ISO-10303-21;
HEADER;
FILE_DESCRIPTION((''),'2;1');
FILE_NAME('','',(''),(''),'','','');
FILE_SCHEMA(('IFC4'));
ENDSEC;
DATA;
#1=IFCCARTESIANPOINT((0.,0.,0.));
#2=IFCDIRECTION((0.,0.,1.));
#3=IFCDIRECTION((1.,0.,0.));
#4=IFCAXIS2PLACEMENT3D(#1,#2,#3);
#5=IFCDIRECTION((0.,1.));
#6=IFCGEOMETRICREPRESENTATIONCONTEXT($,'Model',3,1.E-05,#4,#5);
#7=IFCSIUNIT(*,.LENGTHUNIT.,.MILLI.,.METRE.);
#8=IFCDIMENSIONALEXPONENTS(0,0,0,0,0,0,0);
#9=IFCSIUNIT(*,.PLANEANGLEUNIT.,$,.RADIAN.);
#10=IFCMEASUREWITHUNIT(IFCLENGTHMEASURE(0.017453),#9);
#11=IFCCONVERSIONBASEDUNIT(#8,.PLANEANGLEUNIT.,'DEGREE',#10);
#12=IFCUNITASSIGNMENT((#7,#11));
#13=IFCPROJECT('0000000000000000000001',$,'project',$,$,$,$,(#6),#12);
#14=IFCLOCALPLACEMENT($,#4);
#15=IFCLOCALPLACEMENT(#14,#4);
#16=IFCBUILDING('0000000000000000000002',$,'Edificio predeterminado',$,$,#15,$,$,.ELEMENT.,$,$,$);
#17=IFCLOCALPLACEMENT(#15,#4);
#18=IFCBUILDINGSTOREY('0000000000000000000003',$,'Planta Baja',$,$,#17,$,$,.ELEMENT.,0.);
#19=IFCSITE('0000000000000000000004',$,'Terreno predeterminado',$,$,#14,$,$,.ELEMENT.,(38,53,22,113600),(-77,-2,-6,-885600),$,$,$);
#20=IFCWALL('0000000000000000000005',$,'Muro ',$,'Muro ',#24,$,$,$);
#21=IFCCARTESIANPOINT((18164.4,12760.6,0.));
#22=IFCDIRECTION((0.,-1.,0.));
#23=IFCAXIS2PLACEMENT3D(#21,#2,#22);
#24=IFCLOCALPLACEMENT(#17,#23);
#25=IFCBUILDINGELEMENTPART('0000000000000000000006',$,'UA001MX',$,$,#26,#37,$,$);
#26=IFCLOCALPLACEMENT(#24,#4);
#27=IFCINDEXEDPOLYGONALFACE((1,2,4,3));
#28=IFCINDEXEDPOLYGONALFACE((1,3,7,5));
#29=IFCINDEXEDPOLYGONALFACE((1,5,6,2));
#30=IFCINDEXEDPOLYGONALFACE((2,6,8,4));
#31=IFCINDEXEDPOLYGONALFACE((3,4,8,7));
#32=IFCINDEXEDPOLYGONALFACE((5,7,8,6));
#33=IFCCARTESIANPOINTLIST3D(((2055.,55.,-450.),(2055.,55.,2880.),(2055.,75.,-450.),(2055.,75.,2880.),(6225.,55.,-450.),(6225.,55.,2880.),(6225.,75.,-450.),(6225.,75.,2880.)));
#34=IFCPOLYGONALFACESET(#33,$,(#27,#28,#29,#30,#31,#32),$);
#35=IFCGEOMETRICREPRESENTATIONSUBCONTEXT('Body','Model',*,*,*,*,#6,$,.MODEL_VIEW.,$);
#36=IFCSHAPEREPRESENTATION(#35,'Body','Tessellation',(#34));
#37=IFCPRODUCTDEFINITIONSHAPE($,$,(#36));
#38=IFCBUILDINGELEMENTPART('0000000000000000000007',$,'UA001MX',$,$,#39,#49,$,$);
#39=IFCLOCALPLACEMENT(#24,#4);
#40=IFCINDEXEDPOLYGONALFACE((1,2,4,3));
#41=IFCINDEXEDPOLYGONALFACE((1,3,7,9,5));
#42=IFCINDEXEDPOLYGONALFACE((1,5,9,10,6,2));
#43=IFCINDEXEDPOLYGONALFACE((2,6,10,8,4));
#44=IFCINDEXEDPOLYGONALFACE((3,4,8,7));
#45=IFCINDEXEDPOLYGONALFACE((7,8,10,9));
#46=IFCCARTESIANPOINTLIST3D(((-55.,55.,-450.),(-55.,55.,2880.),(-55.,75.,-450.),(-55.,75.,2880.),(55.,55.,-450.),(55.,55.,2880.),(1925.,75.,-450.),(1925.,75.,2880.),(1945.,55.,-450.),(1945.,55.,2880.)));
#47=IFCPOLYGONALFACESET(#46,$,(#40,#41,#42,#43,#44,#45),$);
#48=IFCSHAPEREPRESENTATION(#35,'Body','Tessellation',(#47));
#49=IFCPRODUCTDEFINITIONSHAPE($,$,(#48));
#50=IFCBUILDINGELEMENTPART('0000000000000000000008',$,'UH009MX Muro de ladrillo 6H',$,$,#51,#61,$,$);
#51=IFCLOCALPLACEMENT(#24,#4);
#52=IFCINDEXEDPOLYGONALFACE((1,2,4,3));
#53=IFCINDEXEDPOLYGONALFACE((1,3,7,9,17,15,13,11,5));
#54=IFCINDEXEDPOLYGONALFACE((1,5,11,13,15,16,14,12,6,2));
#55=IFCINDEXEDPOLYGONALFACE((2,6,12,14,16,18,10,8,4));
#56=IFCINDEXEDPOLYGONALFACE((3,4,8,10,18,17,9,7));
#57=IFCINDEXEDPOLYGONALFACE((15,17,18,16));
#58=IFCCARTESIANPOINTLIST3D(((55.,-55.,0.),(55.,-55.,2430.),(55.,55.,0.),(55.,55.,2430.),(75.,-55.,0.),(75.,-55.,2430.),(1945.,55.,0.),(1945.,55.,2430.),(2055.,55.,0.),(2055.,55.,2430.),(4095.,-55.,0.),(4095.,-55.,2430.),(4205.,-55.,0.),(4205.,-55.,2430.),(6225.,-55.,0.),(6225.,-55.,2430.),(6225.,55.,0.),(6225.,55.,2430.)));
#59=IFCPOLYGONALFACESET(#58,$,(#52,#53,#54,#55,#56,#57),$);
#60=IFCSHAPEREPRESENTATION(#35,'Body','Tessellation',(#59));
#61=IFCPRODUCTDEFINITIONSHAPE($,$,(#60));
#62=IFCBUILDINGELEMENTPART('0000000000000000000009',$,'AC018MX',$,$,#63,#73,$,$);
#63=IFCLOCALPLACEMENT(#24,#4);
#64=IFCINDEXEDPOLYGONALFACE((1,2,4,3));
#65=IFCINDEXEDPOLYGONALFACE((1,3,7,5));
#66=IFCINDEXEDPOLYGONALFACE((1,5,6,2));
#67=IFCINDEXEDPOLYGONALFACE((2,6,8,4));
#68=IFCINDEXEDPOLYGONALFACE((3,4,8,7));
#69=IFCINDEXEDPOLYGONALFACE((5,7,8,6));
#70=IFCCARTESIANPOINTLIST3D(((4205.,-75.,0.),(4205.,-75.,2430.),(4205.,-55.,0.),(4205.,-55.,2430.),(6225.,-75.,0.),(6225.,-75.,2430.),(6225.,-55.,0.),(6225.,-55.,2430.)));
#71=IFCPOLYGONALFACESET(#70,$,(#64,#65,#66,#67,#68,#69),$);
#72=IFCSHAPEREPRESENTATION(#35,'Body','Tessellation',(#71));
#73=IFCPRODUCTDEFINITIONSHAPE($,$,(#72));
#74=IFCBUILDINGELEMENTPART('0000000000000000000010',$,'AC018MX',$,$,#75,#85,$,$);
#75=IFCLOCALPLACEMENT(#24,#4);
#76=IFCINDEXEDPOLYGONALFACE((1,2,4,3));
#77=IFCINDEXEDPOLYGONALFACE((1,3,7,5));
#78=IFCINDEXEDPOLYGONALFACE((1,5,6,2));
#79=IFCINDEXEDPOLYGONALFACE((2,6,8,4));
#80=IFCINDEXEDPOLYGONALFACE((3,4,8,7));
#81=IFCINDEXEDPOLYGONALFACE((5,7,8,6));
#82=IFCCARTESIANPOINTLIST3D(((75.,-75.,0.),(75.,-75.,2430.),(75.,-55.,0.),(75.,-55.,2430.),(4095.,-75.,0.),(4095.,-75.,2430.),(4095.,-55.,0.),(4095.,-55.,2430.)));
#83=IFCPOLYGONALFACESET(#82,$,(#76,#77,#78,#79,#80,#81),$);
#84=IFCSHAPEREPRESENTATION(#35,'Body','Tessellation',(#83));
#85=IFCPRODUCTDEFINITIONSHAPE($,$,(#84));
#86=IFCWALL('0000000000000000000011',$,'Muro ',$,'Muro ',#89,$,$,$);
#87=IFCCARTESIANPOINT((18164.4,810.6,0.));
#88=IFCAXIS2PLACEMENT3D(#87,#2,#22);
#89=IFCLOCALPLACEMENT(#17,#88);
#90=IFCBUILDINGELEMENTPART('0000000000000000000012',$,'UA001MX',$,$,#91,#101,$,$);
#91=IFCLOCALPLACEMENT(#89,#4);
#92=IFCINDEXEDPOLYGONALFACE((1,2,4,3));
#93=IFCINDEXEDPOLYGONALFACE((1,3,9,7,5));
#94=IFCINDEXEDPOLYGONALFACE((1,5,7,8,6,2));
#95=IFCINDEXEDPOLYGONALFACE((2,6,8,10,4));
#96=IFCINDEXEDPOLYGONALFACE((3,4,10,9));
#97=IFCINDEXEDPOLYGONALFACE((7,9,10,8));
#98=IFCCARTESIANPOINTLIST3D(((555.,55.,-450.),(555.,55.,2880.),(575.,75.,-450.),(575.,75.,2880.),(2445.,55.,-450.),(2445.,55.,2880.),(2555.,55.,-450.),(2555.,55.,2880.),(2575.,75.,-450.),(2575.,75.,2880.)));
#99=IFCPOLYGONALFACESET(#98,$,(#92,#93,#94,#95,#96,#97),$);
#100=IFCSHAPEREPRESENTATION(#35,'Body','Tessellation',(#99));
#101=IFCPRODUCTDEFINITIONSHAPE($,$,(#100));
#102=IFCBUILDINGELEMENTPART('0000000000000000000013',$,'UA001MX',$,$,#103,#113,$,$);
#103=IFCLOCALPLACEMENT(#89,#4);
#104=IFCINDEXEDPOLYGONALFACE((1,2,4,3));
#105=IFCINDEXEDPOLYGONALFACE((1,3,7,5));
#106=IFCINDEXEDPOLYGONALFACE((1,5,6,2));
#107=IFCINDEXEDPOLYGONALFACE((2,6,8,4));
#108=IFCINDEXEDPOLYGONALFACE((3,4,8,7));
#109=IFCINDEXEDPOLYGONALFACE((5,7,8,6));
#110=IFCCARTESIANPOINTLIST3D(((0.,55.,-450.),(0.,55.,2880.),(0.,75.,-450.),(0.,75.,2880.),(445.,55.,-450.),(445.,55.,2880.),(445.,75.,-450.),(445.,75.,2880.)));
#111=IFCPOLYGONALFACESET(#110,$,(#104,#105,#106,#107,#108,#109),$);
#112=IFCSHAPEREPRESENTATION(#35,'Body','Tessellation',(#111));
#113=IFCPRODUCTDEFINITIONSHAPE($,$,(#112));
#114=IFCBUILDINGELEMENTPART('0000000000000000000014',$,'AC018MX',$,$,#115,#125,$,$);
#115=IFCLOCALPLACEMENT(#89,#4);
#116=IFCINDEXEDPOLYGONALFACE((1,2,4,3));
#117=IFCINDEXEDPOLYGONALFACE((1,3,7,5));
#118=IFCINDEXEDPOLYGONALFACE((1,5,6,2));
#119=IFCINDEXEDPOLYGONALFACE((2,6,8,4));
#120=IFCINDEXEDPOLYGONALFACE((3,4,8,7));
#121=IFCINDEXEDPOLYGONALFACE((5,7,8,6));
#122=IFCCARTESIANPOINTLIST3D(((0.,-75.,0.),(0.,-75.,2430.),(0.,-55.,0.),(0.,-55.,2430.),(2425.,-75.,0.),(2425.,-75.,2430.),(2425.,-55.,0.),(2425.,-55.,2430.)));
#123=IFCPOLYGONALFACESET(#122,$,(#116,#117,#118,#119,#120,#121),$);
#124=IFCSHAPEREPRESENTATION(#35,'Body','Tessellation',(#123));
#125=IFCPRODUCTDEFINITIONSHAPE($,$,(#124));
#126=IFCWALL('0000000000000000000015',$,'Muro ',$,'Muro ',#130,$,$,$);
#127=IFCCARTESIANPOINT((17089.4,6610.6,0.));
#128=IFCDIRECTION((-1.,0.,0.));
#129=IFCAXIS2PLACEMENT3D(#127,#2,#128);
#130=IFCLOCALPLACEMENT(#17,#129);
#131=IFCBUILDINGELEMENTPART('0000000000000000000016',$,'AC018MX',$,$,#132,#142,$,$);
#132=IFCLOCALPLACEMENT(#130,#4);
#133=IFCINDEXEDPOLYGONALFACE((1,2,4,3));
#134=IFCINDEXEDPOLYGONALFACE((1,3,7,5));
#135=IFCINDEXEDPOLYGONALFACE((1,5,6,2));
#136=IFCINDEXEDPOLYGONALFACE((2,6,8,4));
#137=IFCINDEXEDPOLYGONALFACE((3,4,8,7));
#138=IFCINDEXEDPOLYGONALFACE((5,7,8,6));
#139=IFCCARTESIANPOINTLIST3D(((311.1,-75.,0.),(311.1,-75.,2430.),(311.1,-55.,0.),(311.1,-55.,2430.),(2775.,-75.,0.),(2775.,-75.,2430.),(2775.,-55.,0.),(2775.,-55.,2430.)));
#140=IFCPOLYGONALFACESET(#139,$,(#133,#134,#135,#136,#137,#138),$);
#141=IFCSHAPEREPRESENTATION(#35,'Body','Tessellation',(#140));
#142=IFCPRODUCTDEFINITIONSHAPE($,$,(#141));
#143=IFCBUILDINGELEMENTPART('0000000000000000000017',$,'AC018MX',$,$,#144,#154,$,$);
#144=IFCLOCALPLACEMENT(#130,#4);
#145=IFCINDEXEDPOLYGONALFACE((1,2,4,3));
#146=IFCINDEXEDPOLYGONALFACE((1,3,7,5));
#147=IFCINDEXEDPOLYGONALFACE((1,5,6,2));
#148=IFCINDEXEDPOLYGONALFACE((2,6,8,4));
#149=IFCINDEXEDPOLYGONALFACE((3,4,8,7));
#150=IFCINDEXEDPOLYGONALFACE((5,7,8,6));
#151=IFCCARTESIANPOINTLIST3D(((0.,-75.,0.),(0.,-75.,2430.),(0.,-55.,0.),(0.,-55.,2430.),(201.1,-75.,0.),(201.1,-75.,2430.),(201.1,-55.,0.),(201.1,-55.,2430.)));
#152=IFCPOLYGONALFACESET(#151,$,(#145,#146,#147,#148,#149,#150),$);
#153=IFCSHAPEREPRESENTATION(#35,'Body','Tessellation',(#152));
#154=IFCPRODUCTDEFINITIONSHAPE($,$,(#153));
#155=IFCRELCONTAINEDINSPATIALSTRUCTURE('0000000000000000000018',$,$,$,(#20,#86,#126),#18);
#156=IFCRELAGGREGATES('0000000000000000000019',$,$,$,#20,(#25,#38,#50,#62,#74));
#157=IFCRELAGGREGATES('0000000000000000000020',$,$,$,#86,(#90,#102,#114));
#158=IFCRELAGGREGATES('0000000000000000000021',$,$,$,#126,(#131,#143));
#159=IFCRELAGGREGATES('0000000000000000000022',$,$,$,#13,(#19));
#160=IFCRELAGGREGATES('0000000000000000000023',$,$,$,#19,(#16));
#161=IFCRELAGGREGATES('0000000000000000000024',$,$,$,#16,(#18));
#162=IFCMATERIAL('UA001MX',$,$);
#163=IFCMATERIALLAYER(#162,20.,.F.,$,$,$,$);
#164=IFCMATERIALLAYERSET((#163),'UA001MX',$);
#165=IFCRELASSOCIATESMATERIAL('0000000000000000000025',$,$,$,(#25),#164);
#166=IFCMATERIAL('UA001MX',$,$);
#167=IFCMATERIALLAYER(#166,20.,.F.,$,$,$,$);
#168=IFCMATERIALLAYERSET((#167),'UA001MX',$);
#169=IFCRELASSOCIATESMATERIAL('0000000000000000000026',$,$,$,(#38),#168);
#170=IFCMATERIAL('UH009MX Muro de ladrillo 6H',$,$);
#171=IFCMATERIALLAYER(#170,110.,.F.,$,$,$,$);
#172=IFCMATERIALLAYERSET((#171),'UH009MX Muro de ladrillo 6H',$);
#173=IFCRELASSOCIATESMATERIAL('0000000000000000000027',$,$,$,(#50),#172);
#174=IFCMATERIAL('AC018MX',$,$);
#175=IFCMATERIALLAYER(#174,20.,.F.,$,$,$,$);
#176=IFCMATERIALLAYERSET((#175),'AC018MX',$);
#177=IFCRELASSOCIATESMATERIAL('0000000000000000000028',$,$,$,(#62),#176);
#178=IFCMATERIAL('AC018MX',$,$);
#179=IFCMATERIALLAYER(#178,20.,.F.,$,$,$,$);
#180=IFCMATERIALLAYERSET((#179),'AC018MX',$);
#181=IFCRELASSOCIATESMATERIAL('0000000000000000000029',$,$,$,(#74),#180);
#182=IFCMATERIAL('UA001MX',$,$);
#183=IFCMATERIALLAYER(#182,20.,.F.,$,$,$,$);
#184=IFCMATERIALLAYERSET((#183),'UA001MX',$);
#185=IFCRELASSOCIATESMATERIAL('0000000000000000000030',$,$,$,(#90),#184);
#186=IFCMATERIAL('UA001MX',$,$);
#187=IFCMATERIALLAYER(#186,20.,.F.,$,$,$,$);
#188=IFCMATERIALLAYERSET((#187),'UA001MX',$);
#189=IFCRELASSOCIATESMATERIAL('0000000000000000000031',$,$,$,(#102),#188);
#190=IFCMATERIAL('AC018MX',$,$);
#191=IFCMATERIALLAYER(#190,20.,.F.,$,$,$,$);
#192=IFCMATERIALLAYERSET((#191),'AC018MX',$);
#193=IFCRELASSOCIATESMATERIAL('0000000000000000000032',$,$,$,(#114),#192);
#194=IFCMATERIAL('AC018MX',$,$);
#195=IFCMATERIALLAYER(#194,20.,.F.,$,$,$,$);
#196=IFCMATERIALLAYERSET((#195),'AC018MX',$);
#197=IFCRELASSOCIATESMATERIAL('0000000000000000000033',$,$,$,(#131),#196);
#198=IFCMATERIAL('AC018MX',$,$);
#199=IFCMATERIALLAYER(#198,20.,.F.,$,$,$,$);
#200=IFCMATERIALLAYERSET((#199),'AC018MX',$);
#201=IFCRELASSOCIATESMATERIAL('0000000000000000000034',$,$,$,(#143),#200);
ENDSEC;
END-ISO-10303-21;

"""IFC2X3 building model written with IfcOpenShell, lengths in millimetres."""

from ifc_helpers import new_model, entity, si_unit, converted_unit, direction, frame, origin_with_axes, place, context, subcontext, project, spatial, polyline, outline, extrude, material, layer, layer_set, layer_usage, element, aggregate, save


model = new_model("IFC2X3")

# Units and contexts
model_context = context("Model", 3, precision=1e-05, world=origin_with_axes(), true_north=direction((0.0, 1.0)))
body_context = subcontext(model_context, "Body", "Model", "MODEL_VIEW")
ifc_project = project(units=[si_unit("LENGTHUNIT", "METRE", prefix="MILLI"), converted_unit("PLANEANGLEUNIT", "DEGREE", entity("IfcLengthMeasure", 0.017453), si_unit("PLANEANGLEUNIT", "RADIAN"), dimensions=[0, 0, 0, 0, 0, 0, 0])], contexts=[model_context])

# Site, building, storey
site_placement = place(None, origin_with_axes())
site = spatial("IfcSite", under=ifc_project, at=site_placement, Name="Terreno predeterminado", CompositionType="ELEMENT", RefLatitude=(38, 53, 22, 113600), RefLongitude=(-77, -2, -6, -885600))
building_placement = place(site_placement, origin_with_axes())
building = spatial("IfcBuilding", under=site, at=building_placement, Name="Edificio predeterminado", CompositionType="ELEMENT")
storey_placement = place(building_placement, origin_with_axes())
storey = spatial("IfcBuildingStorey", under=building, at=storey_placement, Name="Planta Baja", CompositionType="ELEMENT", Elevation=0.0)

# Walls, building element parts
wall_1_placement = place(storey_placement, frame((18164.4, 12760.6, 0.0), z_axis=(0.0, 0.0, 1.0), x_axis=(0.0, -1.0, 0.0)))
wall_1 = element("IfcWall", 1, at=wall_1_placement, inside=storey, Name="Muro ", ObjectType="Muro ")
ifc_material_1 = material(Name="UA001MX")
ifc_layer_1 = layer(ifc_material_1, 20.0, ventilated=False)
ifc_layer_set_1 = layer_set([ifc_layer_1], Name="UA001MX")
ifc_layer_usage_1 = layer_usage(ifc_layer_set_1, "AXIS2", "NEGATIVE", -75.0)
building_element_part_1_placement = place(wall_1_placement, origin_with_axes())
building_element_part_1 = element("IfcBuildingElementPart", 2, at=building_element_part_1_placement, material=ifc_layer_usage_1, Name="UA001MX", context=body_context, shape_type="SweptSolid", body=[
    extrude(outline(polyline([(6225.0, 75.0), (6225.0, 55.0), (2055.0, 55.0), (2055.0, 75.0), (6225.0, 75.0)])), frame((0.0, 0.0, -450.0), z_axis=(0.0, 0.0, 1.0), x_axis=(1.0, 0.0, 0.0)), (0.0, 0.0, 1.0), 3330.0),
])
ifc_material_2 = material(Name="UA001MX")
ifc_layer_2 = layer(ifc_material_2, 20.0, ventilated=False)
ifc_layer_set_2 = layer_set([ifc_layer_2], Name="UA001MX")
ifc_layer_usage_2 = layer_usage(ifc_layer_set_2, "AXIS2", "NEGATIVE", -75.0)
building_element_part_2_placement = place(wall_1_placement, origin_with_axes())
building_element_part_2 = element("IfcBuildingElementPart", 3, at=building_element_part_2_placement, material=ifc_layer_usage_2, Name="UA001MX", context=body_context, shape_type="SweptSolid", body=[
    extrude(outline(polyline([(1925.0, 75.0), (1945.0, 55.0), (55.0, 55.0), (-55.0, 55.0), (-55.0, 75.0), (1925.0, 75.0)])), frame((0.0, 0.0, -450.0), z_axis=(0.0, 0.0, 1.0), x_axis=(1.0, 0.0, 0.0)), (0.0, 0.0, 1.0), 3330.0),
])
ifc_material_3 = material(Name="UH009MX Muro de ladrillo 6H")
ifc_layer_3 = layer(ifc_material_3, 110.0, ventilated=False)
ifc_layer_set_3 = layer_set([ifc_layer_3], Name="UH009MX Muro de ladrillo 6H")
ifc_layer_usage_3 = layer_usage(ifc_layer_set_3, "AXIS2", "NEGATIVE", -55.0)
building_element_part_3_placement = place(wall_1_placement, origin_with_axes())
building_element_part_3 = element("IfcBuildingElementPart", 4, at=building_element_part_3_placement, material=ifc_layer_usage_3, Name="UH009MX Muro de ladrillo 6H", context=body_context, shape_type="SweptSolid", body=[
    extrude(outline(polyline([(6225.0, 55.0), (6225.0, -55.0), (4205.0, -55.0), (4095.0, -55.0), (75.0, -55.0), (55.0, -55.0), (55.0, 55.0), (1945.0, 55.0), (2055.0, 55.0), (6225.0, 55.0)])), origin_with_axes(), (0.0, 0.0, 1.0), 2430.0),
])
ifc_material_4 = material(Name="AC018MX")
ifc_layer_4 = layer(ifc_material_4, 20.0, ventilated=False)
ifc_layer_set_4 = layer_set([ifc_layer_4], Name="AC018MX")
ifc_layer_usage_4 = layer_usage(ifc_layer_set_4, "AXIS2", "NEGATIVE", 55.0)
building_element_part_4_placement = place(wall_1_placement, origin_with_axes())
building_element_part_4 = element("IfcBuildingElementPart", 5, at=building_element_part_4_placement, material=ifc_layer_usage_4, Name="AC018MX", context=body_context, shape_type="SweptSolid", body=[
    extrude(outline(polyline([(6225.0, -55.0), (6225.0, -75.0), (4205.0, -75.0), (4205.0, -55.0), (6225.0, -55.0)])), origin_with_axes(), (0.0, 0.0, 1.0), 2430.0),
])
ifc_material_5 = material(Name="AC018MX")
ifc_layer_5 = layer(ifc_material_5, 20.0, ventilated=False)
ifc_layer_set_5 = layer_set([ifc_layer_5], Name="AC018MX")
ifc_layer_usage_5 = layer_usage(ifc_layer_set_5, "AXIS2", "NEGATIVE", 55.0)
building_element_part_5_placement = place(wall_1_placement, origin_with_axes())
building_element_part_5 = element("IfcBuildingElementPart", 6, at=building_element_part_5_placement, material=ifc_layer_usage_5, Name="AC018MX", context=body_context, shape_type="SweptSolid", body=[
    extrude(outline(polyline([(4095.0, -55.0), (4095.0, -75.0), (75.0, -75.0), (75.0, -55.0), (4095.0, -55.0)])), origin_with_axes(), (0.0, 0.0, 1.0), 2430.0),
])
aggregate(wall_1, [building_element_part_1, building_element_part_2, building_element_part_3, building_element_part_4, building_element_part_5])
wall_2_placement = place(storey_placement, frame((18164.4, 810.6, 0.0), z_axis=(0.0, 0.0, 1.0), x_axis=(0.0, -1.0, 0.0)))
wall_2 = element("IfcWall", 7, at=wall_2_placement, inside=storey, Name="Muro ", ObjectType="Muro ")
ifc_material_6 = material(Name="UA001MX")
ifc_layer_6 = layer(ifc_material_6, 20.0, ventilated=False)
ifc_layer_set_6 = layer_set([ifc_layer_6], Name="UA001MX")
ifc_layer_usage_6 = layer_usage(ifc_layer_set_6, "AXIS2", "NEGATIVE", -75.0)
building_element_part_6_placement = place(wall_2_placement, origin_with_axes())
building_element_part_6 = element("IfcBuildingElementPart", 8, at=building_element_part_6_placement, material=ifc_layer_usage_6, Name="UA001MX", context=body_context, shape_type="SweptSolid", body=[
    extrude(outline(polyline([(2575.0, 75.0), (2555.0, 55.0), (2445.0, 55.0), (555.0, 55.0), (575.0, 75.0), (2575.0, 75.0)])), frame((0.0, 0.0, -450.0), z_axis=(0.0, 0.0, 1.0), x_axis=(1.0, 0.0, 0.0)), (0.0, 0.0, 1.0), 3330.0),
])
ifc_material_7 = material(Name="UA001MX")
ifc_layer_7 = layer(ifc_material_7, 20.0, ventilated=False)
ifc_layer_set_7 = layer_set([ifc_layer_7], Name="UA001MX")
ifc_layer_usage_7 = layer_usage(ifc_layer_set_7, "AXIS2", "NEGATIVE", -75.0)
building_element_part_7_placement = place(wall_2_placement, origin_with_axes())
building_element_part_7 = element("IfcBuildingElementPart", 9, at=building_element_part_7_placement, material=ifc_layer_usage_7, Name="UA001MX", context=body_context, shape_type="SweptSolid", body=[
    extrude(outline(polyline([(445.0, 75.0), (445.0, 55.0), (0.0, 55.0), (0.0, 75.0), (445.0, 75.0)])), frame((0.0, 0.0, -450.0), z_axis=(0.0, 0.0, 1.0), x_axis=(1.0, 0.0, 0.0)), (0.0, 0.0, 1.0), 3330.0),
])
ifc_material_8 = material(Name="AC018MX")
ifc_layer_8 = layer(ifc_material_8, 20.0, ventilated=False)
ifc_layer_set_8 = layer_set([ifc_layer_8], Name="AC018MX")
ifc_layer_usage_8 = layer_usage(ifc_layer_set_8, "AXIS2", "NEGATIVE", 55.0)
building_element_part_8_placement = place(wall_2_placement, origin_with_axes())
building_element_part_8 = element("IfcBuildingElementPart", 10, at=building_element_part_8_placement, material=ifc_layer_usage_8, Name="AC018MX", context=body_context, shape_type="SweptSolid", body=[
    extrude(outline(polyline([(2425.0, -55.0), (2425.0, -75.0), (0.0, -75.0), (0.0, -55.0), (2425.0, -55.0)])), origin_with_axes(), (0.0, 0.0, 1.0), 2430.0),
])
aggregate(wall_2, [building_element_part_6, building_element_part_7, building_element_part_8])
wall_3_placement = place(storey_placement, frame((17089.4, 6610.6, 0.0), z_axis=(0.0, 0.0, 1.0), x_axis=(-1.0, 0.0, 0.0)))
wall_3 = element("IfcWall", 11, at=wall_3_placement, inside=storey, Name="Muro ", ObjectType="Muro ")
ifc_material_9 = material(Name="AC018MX")
ifc_layer_9 = layer(ifc_material_9, 20.0, ventilated=False)
ifc_layer_set_9 = layer_set([ifc_layer_9], Name="AC018MX")
ifc_layer_usage_9 = layer_usage(ifc_layer_set_9, "AXIS2", "NEGATIVE", 55.0)
building_element_part_9_placement = place(wall_3_placement, origin_with_axes())
building_element_part_9 = element("IfcBuildingElementPart", 12, at=building_element_part_9_placement, material=ifc_layer_usage_9, Name="AC018MX", context=body_context, shape_type="SweptSolid", body=[
    extrude(outline(polyline([(2775.0, -55.0), (2775.0, -75.0), (311.1, -75.0), (311.1, -55.0), (2775.0, -55.0)])), origin_with_axes(), (0.0, 0.0, 1.0), 2430.0),
])
ifc_material_10 = material(Name="AC018MX")
ifc_layer_10 = layer(ifc_material_10, 20.0, ventilated=False)
ifc_layer_set_10 = layer_set([ifc_layer_10], Name="AC018MX")
ifc_layer_usage_10 = layer_usage(ifc_layer_set_10, "AXIS2", "NEGATIVE", 55.0)
building_element_part_10_placement = place(wall_3_placement, origin_with_axes())
building_element_part_10 = element("IfcBuildingElementPart", 13, at=building_element_part_10_placement, material=ifc_layer_usage_10, Name="AC018MX", context=body_context, shape_type="SweptSolid", body=[
    extrude(outline(polyline([(201.1, -55.0), (201.1, -75.0), (0.0, -75.0), (0.0, -55.0), (201.1, -55.0)])), origin_with_axes(), (0.0, 0.0, 1.0), 2430.0),
])
aggregate(wall_3, [building_element_part_9, building_element_part_10])

save(model, "model.ifc")
